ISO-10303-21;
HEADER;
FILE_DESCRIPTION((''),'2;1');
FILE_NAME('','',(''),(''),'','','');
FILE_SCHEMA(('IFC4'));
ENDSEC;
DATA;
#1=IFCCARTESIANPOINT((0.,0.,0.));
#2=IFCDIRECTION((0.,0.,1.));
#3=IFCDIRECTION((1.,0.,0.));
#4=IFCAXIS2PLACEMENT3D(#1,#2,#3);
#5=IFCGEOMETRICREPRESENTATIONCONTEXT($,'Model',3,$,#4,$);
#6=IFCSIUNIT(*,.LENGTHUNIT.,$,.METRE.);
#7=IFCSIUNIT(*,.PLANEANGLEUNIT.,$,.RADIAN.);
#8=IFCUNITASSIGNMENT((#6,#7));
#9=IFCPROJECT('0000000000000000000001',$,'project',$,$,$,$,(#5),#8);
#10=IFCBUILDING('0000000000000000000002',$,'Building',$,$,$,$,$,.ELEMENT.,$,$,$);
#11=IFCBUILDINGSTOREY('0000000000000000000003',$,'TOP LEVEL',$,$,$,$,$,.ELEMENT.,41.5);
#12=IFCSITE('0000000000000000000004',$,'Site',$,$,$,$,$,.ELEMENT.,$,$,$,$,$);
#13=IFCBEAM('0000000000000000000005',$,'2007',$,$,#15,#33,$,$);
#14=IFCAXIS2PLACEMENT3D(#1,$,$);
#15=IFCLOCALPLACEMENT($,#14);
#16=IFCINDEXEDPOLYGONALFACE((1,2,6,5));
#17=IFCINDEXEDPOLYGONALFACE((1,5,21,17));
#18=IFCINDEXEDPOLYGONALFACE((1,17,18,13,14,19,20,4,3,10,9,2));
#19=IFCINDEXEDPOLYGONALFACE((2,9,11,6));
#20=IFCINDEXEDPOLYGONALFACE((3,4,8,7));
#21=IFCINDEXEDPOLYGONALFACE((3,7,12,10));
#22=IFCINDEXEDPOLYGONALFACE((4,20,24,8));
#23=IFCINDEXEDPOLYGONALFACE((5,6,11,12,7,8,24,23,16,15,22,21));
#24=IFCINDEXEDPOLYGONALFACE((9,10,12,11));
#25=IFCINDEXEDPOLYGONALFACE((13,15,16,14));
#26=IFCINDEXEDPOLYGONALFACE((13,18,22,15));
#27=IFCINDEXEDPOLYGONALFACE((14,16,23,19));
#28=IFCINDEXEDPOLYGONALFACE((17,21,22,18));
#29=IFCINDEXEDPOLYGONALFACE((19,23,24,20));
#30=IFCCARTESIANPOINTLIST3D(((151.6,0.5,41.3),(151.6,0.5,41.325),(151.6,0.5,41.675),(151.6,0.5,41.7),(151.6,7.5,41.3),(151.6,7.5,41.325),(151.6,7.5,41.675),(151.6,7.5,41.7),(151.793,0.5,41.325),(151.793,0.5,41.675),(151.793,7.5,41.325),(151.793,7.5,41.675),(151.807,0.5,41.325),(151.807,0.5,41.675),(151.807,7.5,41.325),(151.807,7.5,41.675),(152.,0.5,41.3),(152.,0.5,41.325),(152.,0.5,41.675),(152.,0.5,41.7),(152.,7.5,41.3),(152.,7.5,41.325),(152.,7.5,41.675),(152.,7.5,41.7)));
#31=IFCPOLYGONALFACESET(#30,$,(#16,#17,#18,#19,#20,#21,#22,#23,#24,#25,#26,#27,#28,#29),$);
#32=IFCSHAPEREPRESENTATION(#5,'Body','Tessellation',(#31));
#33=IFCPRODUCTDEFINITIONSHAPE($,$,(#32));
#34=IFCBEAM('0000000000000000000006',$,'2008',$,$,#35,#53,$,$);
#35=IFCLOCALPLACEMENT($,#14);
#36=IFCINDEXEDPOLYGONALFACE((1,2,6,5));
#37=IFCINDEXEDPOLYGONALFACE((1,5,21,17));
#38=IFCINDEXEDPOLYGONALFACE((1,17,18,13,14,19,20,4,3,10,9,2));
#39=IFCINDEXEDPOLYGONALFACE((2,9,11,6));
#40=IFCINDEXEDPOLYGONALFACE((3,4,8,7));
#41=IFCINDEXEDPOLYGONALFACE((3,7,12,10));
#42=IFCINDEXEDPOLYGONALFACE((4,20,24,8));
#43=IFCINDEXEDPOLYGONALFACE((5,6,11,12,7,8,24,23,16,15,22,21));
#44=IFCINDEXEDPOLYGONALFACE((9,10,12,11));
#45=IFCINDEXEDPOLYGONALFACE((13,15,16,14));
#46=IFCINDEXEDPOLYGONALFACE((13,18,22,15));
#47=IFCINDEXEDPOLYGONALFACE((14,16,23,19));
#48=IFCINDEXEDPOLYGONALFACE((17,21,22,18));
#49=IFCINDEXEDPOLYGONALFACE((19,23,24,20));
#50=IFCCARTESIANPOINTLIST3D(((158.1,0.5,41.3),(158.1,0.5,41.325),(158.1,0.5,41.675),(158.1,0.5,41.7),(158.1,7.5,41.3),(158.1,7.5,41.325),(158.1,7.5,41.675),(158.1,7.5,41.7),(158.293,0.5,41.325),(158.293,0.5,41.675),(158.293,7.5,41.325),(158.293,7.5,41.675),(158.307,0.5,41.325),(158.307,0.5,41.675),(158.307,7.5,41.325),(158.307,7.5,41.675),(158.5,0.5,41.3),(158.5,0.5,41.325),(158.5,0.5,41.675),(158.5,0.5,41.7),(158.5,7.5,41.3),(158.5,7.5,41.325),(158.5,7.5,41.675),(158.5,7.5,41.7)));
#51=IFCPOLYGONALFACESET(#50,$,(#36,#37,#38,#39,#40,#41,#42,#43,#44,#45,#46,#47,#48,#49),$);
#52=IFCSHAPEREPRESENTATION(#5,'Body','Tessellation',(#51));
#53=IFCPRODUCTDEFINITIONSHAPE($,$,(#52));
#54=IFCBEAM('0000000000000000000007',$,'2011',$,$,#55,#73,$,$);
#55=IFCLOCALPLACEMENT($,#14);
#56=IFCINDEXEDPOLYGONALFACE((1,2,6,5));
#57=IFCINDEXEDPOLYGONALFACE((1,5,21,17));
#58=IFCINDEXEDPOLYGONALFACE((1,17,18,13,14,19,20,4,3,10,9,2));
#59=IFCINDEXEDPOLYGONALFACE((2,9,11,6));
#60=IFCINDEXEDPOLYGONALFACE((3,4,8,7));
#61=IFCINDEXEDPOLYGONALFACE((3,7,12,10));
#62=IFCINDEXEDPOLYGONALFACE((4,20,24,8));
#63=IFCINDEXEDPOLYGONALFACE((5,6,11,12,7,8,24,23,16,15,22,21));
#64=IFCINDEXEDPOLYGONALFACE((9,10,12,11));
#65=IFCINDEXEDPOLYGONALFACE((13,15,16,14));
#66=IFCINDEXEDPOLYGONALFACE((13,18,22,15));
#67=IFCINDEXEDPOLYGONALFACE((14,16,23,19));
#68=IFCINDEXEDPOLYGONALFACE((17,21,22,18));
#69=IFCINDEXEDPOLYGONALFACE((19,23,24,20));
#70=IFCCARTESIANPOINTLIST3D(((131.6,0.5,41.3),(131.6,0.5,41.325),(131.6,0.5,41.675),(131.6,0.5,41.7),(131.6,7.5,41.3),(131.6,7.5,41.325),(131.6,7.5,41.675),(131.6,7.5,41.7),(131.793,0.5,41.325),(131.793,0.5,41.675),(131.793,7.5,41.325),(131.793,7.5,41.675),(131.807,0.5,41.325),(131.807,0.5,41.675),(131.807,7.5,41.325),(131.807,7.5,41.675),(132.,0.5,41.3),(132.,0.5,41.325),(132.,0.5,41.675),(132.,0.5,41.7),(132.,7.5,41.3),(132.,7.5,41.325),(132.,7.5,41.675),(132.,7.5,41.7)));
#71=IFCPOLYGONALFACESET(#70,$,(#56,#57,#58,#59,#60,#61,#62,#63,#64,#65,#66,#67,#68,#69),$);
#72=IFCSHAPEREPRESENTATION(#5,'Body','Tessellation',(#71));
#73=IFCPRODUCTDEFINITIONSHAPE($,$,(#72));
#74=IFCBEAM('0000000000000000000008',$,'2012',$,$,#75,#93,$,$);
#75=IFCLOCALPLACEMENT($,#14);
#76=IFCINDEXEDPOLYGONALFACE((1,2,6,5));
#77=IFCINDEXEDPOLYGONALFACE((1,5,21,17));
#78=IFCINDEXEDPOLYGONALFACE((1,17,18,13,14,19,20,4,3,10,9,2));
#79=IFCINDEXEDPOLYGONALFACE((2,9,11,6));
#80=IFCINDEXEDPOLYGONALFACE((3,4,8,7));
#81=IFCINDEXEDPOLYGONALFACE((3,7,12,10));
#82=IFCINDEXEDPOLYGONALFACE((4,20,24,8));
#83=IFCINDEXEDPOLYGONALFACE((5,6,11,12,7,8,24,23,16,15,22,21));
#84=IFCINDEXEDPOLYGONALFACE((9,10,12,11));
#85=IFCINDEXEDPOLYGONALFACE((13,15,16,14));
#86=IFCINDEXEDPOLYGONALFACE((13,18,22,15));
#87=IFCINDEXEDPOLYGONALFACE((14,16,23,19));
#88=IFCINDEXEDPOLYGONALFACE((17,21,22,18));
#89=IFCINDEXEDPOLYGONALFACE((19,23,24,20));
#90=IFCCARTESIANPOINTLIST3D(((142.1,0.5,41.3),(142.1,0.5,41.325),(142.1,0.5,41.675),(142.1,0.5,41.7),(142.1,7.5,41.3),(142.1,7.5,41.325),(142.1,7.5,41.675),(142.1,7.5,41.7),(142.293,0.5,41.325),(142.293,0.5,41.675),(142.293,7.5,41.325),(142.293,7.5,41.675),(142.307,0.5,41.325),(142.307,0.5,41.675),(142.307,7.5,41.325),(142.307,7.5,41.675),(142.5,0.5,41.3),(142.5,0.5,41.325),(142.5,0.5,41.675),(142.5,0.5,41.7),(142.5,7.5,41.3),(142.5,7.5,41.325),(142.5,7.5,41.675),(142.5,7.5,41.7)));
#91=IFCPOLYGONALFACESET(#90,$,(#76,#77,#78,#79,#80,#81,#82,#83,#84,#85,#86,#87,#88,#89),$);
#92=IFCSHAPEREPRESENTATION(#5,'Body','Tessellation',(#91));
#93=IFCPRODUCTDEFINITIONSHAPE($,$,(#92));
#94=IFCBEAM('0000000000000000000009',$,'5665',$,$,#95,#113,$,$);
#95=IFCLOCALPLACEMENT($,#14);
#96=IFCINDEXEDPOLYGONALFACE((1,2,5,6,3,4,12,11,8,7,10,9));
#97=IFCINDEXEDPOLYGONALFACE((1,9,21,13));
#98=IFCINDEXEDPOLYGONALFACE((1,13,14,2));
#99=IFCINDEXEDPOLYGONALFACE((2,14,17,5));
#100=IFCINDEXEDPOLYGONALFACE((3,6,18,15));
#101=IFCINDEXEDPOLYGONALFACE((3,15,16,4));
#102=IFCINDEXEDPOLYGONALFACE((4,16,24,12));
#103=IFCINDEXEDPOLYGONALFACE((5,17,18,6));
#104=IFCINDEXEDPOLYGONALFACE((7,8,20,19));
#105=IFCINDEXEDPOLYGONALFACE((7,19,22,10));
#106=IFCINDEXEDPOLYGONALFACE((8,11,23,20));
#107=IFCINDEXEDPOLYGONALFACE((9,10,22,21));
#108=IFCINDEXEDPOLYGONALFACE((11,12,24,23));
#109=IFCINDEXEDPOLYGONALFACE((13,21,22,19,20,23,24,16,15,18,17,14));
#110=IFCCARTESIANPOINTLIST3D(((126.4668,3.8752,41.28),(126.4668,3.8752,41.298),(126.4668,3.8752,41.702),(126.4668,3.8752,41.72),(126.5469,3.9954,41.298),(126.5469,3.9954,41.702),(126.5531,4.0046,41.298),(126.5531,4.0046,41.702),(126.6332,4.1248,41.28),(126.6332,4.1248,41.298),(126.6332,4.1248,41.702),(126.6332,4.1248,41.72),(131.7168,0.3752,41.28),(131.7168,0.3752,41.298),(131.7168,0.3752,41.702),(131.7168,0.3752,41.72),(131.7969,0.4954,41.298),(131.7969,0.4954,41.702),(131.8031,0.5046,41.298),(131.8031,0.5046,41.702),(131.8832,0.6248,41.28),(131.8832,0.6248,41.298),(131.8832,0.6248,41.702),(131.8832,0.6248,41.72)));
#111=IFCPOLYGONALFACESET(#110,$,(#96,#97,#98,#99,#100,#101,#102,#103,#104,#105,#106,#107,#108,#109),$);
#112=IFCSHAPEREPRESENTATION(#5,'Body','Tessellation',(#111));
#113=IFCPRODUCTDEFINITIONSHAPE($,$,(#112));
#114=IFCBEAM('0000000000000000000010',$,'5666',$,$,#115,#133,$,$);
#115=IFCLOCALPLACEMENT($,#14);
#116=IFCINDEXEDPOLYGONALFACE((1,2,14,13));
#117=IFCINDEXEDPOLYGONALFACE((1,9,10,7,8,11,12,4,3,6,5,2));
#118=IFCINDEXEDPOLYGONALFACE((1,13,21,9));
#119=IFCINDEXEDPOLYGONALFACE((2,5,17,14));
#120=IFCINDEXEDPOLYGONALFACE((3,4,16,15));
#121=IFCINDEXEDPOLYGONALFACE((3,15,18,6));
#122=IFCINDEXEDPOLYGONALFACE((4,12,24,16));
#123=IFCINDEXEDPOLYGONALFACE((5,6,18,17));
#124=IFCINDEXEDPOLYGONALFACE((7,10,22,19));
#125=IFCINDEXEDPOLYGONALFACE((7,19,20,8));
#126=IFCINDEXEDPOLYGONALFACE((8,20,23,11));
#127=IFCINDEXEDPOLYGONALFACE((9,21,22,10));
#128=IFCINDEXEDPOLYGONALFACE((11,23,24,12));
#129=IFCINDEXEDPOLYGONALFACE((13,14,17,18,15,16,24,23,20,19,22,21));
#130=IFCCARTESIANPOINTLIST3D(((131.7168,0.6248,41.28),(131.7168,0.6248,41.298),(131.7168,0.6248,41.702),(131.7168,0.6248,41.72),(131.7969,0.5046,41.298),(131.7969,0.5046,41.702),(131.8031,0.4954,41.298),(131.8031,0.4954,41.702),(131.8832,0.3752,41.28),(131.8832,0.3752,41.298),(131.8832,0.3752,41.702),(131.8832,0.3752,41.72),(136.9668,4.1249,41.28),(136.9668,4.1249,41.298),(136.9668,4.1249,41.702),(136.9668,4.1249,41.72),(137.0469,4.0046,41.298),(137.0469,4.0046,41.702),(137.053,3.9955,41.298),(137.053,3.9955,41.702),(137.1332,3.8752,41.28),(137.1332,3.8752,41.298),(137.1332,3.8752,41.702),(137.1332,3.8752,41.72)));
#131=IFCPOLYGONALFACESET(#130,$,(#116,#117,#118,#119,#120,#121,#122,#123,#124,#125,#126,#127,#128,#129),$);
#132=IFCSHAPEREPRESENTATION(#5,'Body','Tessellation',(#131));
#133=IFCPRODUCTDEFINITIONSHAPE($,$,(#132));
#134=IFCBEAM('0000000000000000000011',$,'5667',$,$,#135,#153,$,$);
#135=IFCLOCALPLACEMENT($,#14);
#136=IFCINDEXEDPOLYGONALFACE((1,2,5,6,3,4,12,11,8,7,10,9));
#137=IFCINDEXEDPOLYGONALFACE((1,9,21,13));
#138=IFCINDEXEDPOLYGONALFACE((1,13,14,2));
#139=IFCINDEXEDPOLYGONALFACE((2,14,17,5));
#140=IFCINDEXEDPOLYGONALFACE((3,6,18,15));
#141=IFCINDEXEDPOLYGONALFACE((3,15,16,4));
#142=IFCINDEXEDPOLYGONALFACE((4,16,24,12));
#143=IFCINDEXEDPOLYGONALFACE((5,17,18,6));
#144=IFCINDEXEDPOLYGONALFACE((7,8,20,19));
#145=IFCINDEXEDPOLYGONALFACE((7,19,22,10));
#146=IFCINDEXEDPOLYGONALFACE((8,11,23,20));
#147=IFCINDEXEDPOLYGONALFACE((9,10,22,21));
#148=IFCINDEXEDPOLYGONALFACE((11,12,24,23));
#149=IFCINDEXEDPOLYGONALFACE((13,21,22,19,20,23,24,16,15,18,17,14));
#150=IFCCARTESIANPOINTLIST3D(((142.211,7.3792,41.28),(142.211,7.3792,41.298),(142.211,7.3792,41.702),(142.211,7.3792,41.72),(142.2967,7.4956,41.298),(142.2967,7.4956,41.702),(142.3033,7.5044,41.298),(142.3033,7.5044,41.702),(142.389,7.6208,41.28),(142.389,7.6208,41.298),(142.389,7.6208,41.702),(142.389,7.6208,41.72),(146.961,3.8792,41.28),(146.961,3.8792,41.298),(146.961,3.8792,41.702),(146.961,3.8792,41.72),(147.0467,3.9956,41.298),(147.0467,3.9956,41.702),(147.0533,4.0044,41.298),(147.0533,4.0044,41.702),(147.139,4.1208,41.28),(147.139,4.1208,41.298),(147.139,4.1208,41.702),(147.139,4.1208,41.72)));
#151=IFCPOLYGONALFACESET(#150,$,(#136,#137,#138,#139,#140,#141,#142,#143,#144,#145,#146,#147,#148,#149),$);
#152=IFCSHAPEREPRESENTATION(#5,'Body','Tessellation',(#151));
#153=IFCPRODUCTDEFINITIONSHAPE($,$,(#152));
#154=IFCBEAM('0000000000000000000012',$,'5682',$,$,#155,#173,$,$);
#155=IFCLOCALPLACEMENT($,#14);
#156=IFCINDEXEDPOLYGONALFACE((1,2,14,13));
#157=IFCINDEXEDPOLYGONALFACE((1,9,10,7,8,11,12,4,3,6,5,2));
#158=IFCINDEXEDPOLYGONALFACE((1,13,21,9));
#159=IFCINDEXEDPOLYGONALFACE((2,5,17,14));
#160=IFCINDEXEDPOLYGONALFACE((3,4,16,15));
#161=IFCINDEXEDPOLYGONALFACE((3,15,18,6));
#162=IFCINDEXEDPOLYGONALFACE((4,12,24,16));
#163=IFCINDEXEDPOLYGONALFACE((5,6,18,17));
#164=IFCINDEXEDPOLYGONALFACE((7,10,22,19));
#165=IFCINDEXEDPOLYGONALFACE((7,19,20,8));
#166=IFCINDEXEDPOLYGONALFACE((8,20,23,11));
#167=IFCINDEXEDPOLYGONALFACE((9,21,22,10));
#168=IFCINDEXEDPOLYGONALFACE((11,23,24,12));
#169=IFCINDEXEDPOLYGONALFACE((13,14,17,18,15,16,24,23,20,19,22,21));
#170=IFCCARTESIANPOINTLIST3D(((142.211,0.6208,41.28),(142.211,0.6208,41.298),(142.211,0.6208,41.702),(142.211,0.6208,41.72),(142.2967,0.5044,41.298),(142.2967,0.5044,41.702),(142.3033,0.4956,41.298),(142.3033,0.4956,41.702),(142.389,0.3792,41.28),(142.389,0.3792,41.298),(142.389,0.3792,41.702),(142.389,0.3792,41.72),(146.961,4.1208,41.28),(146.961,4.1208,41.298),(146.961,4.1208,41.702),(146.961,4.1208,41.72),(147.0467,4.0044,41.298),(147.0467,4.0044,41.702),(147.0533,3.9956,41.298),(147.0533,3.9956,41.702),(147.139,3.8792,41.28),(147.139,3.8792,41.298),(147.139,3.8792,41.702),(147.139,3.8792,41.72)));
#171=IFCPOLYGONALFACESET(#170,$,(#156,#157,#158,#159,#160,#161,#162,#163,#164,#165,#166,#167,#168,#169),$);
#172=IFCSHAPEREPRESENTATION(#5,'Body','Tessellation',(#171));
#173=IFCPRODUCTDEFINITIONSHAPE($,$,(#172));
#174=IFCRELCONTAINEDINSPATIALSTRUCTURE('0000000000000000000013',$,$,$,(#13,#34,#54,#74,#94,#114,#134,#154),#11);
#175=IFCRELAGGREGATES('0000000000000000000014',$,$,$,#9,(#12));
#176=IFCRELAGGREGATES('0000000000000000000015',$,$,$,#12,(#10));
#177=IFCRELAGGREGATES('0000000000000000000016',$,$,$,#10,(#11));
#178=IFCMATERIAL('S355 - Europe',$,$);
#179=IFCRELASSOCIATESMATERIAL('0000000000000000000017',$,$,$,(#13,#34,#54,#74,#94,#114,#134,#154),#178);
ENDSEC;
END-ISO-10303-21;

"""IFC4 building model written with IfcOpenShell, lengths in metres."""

from ifc_helpers import new_model, si_unit, frame, origin_with_axes, origin_2d_with_axis, place, context, project, spatial, i_section, extrude, material, material_profile, profile_set, profile_usage, element, save


model = new_model("IFC4")

# Units and contexts
model_context = context("Model", 3, world=origin_with_axes())
ifc_project = project(units=[si_unit("LENGTHUNIT", "METRE"), si_unit("PLANEANGLEUNIT", "RADIAN")], contexts=[model_context])

# Site, building, storey
site = spatial("IfcSite", under=ifc_project, Name="Site", CompositionType="ELEMENT")
building = spatial("IfcBuilding", under=site, Name="Building", CompositionType="ELEMENT")
storey = spatial("IfcBuildingStorey", under=building, Name="TOP LEVEL", CompositionType="ELEMENT", Elevation=41.5)

# Beams
ifc_material = material(Name="S355 - Europe")
ifc_material_profile_1 = material_profile(ifc_material, i_section(OverallWidth=0.4, OverallDepth=0.4, WebThickness=0.014, FlangeThickness=0.025, at=origin_2d_with_axis()))
ifc_profile_set_1 = profile_set([ifc_material_profile_1])
ifc_profile_usage_1 = profile_usage(ifc_profile_set_1, cardinal=10)
beam_1_placement = place(None, frame((151.8, 0.5, 41.5), z_axis=(0.0, 1.0, 0.0), x_axis=(-1.0, 0.0, 0.0)))
element("IfcBeam", 1, at=beam_1_placement, inside=storey, material=ifc_profile_usage_1, Name="2007", context=model_context, shape_type="SweptSolid", body=[
    extrude(i_section(OverallWidth=0.4, OverallDepth=0.4, WebThickness=0.014, FlangeThickness=0.025, at=origin_2d_with_axis()), origin_with_axes(), (0.0, 0.0, 1.0), 7.0),
])
ifc_material_profile_2 = material_profile(ifc_material, i_section(OverallWidth=0.4, OverallDepth=0.4, WebThickness=0.014, FlangeThickness=0.025, at=origin_2d_with_axis()))
ifc_profile_set_2 = profile_set([ifc_material_profile_2])
ifc_profile_usage_2 = profile_usage(ifc_profile_set_2, cardinal=10)
beam_2_placement = place(None, frame((158.3, 7.5, 41.5), z_axis=(0.0, -1.0, 0.0), x_axis=(1.0, 0.0, 0.0)))
element("IfcBeam", 2, at=beam_2_placement, inside=storey, material=ifc_profile_usage_2, Name="2008", context=model_context, shape_type="SweptSolid", body=[
    extrude(i_section(OverallWidth=0.4, OverallDepth=0.4, WebThickness=0.014, FlangeThickness=0.025, at=origin_2d_with_axis()), origin_with_axes(), (0.0, 0.0, 1.0), 7.0),
])
ifc_material_profile_3 = material_profile(ifc_material, i_section(OverallWidth=0.4, OverallDepth=0.4, WebThickness=0.014, FlangeThickness=0.025, at=origin_2d_with_axis()))
ifc_profile_set_3 = profile_set([ifc_material_profile_3])
ifc_profile_usage_3 = profile_usage(ifc_profile_set_3, cardinal=10)
beam_3_placement = place(None, frame((131.8, 7.5, 41.5), z_axis=(0.0, -1.0, 0.0), x_axis=(1.0, 0.0, 0.0)))
element("IfcBeam", 3, at=beam_3_placement, inside=storey, material=ifc_profile_usage_3, Name="2011", context=model_context, shape_type="SweptSolid", body=[
    extrude(i_section(OverallWidth=0.4, OverallDepth=0.4, WebThickness=0.014, FlangeThickness=0.025, at=origin_2d_with_axis()), origin_with_axes(), (0.0, 0.0, 1.0), 7.0),
])
ifc_material_profile_4 = material_profile(ifc_material, i_section(OverallWidth=0.4, OverallDepth=0.4, WebThickness=0.014, FlangeThickness=0.025, at=origin_2d_with_axis()))
ifc_profile_set_4 = profile_set([ifc_material_profile_4])
ifc_profile_usage_4 = profile_usage(ifc_profile_set_4, cardinal=10)
beam_4_placement = place(None, frame((142.3, 7.5, 41.5), z_axis=(0.0, -1.0, 0.0), x_axis=(1.0, 0.0, 0.0)))
element("IfcBeam", 4, at=beam_4_placement, inside=storey, material=ifc_profile_usage_4, Name="2012", context=model_context, shape_type="SweptSolid", body=[
    extrude(i_section(OverallWidth=0.4, OverallDepth=0.4, WebThickness=0.014, FlangeThickness=0.025, at=origin_2d_with_axis()), origin_with_axes(), (0.0, 0.0, 1.0), 7.0),
])
ifc_material_profile_5 = material_profile(ifc_material, i_section(OverallWidth=0.3, OverallDepth=0.44, WebThickness=0.011, FlangeThickness=0.018, at=origin_2d_with_axis()))
ifc_profile_set_5 = profile_set([ifc_material_profile_5])
ifc_profile_usage_5 = profile_usage(ifc_profile_set_5, cardinal=10)
beam_5_placement = place(None, frame((131.8, 0.5, 41.5), z_axis=(-0.83205, 0.5547, 0.0), x_axis=(-0.5547, -0.83205, 0.0)))
element("IfcBeam", 5, at=beam_5_placement, inside=storey, material=ifc_profile_usage_5, Name="5665", context=model_context, shape_type="SweptSolid", body=[
    extrude(i_section(OverallWidth=0.3, OverallDepth=0.44, WebThickness=0.011, FlangeThickness=0.018, at=origin_2d_with_axis()), origin_with_axes(), (0.0, 0.0, 1.0), 6.3097),
])
ifc_material_profile_6 = material_profile(ifc_material, i_section(OverallWidth=0.3, OverallDepth=0.44, WebThickness=0.011, FlangeThickness=0.018, at=origin_2d_with_axis()))
ifc_profile_set_6 = profile_set([ifc_material_profile_6])
ifc_profile_usage_6 = profile_usage(ifc_profile_set_6, cardinal=10)
beam_6_placement = place(None, frame((131.8, 0.5, 41.5), z_axis=(0.832045, 0.554708, 0.0), x_axis=(-0.554708, 0.832045, 0.0)))
element("IfcBeam", 6, at=beam_6_placement, inside=storey, material=ifc_profile_usage_6, Name="5666", context=model_context, shape_type="SweptSolid", body=[
    extrude(i_section(OverallWidth=0.3, OverallDepth=0.44, WebThickness=0.011, FlangeThickness=0.018, at=origin_2d_with_axis()), origin_with_axes(), (0.0, 0.0, 1.0), 6.3097),
])
ifc_material_profile_7 = material_profile(ifc_material, i_section(OverallWidth=0.3, OverallDepth=0.44, WebThickness=0.011, FlangeThickness=0.018, at=origin_2d_with_axis()))
ifc_profile_set_7 = profile_set([ifc_material_profile_7])
ifc_profile_usage_7 = profile_usage(ifc_profile_set_7, cardinal=10)
beam_7_placement = place(None, frame((142.3, 7.5, 41.5), z_axis=(0.805056, -0.593199, 0.0), x_axis=(0.593199, 0.805056, 0.0)))
element("IfcBeam", 7, at=beam_7_placement, inside=storey, material=ifc_profile_usage_7, Name="5667", context=model_context, shape_type="SweptSolid", body=[
    extrude(i_section(OverallWidth=0.3, OverallDepth=0.44, WebThickness=0.011, FlangeThickness=0.018, at=origin_2d_with_axis()), origin_with_axes(), (0.0, 0.0, 1.0), 5.9002),
])
ifc_material_profile_8 = material_profile(ifc_material, i_section(OverallWidth=0.3, OverallDepth=0.44, WebThickness=0.011, FlangeThickness=0.018, at=origin_2d_with_axis()))
ifc_profile_set_8 = profile_set([ifc_material_profile_8])
ifc_profile_usage_8 = profile_usage(ifc_profile_set_8, cardinal=10)
beam_8_placement = place(None, frame((142.3, 0.5, 41.5), z_axis=(0.805056, 0.593199, 0.0), x_axis=(-0.593199, 0.805056, 0.0)))
element("IfcBeam", 8, at=beam_8_placement, inside=storey, material=ifc_profile_usage_8, Name="5682", context=model_context, shape_type="SweptSolid", body=[
    extrude(i_section(OverallWidth=0.3, OverallDepth=0.44, WebThickness=0.011, FlangeThickness=0.018, at=origin_2d_with_axis()), origin_with_axes(), (0.0, 0.0, 1.0), 5.9002),
])

save(model, "model.ifc")
